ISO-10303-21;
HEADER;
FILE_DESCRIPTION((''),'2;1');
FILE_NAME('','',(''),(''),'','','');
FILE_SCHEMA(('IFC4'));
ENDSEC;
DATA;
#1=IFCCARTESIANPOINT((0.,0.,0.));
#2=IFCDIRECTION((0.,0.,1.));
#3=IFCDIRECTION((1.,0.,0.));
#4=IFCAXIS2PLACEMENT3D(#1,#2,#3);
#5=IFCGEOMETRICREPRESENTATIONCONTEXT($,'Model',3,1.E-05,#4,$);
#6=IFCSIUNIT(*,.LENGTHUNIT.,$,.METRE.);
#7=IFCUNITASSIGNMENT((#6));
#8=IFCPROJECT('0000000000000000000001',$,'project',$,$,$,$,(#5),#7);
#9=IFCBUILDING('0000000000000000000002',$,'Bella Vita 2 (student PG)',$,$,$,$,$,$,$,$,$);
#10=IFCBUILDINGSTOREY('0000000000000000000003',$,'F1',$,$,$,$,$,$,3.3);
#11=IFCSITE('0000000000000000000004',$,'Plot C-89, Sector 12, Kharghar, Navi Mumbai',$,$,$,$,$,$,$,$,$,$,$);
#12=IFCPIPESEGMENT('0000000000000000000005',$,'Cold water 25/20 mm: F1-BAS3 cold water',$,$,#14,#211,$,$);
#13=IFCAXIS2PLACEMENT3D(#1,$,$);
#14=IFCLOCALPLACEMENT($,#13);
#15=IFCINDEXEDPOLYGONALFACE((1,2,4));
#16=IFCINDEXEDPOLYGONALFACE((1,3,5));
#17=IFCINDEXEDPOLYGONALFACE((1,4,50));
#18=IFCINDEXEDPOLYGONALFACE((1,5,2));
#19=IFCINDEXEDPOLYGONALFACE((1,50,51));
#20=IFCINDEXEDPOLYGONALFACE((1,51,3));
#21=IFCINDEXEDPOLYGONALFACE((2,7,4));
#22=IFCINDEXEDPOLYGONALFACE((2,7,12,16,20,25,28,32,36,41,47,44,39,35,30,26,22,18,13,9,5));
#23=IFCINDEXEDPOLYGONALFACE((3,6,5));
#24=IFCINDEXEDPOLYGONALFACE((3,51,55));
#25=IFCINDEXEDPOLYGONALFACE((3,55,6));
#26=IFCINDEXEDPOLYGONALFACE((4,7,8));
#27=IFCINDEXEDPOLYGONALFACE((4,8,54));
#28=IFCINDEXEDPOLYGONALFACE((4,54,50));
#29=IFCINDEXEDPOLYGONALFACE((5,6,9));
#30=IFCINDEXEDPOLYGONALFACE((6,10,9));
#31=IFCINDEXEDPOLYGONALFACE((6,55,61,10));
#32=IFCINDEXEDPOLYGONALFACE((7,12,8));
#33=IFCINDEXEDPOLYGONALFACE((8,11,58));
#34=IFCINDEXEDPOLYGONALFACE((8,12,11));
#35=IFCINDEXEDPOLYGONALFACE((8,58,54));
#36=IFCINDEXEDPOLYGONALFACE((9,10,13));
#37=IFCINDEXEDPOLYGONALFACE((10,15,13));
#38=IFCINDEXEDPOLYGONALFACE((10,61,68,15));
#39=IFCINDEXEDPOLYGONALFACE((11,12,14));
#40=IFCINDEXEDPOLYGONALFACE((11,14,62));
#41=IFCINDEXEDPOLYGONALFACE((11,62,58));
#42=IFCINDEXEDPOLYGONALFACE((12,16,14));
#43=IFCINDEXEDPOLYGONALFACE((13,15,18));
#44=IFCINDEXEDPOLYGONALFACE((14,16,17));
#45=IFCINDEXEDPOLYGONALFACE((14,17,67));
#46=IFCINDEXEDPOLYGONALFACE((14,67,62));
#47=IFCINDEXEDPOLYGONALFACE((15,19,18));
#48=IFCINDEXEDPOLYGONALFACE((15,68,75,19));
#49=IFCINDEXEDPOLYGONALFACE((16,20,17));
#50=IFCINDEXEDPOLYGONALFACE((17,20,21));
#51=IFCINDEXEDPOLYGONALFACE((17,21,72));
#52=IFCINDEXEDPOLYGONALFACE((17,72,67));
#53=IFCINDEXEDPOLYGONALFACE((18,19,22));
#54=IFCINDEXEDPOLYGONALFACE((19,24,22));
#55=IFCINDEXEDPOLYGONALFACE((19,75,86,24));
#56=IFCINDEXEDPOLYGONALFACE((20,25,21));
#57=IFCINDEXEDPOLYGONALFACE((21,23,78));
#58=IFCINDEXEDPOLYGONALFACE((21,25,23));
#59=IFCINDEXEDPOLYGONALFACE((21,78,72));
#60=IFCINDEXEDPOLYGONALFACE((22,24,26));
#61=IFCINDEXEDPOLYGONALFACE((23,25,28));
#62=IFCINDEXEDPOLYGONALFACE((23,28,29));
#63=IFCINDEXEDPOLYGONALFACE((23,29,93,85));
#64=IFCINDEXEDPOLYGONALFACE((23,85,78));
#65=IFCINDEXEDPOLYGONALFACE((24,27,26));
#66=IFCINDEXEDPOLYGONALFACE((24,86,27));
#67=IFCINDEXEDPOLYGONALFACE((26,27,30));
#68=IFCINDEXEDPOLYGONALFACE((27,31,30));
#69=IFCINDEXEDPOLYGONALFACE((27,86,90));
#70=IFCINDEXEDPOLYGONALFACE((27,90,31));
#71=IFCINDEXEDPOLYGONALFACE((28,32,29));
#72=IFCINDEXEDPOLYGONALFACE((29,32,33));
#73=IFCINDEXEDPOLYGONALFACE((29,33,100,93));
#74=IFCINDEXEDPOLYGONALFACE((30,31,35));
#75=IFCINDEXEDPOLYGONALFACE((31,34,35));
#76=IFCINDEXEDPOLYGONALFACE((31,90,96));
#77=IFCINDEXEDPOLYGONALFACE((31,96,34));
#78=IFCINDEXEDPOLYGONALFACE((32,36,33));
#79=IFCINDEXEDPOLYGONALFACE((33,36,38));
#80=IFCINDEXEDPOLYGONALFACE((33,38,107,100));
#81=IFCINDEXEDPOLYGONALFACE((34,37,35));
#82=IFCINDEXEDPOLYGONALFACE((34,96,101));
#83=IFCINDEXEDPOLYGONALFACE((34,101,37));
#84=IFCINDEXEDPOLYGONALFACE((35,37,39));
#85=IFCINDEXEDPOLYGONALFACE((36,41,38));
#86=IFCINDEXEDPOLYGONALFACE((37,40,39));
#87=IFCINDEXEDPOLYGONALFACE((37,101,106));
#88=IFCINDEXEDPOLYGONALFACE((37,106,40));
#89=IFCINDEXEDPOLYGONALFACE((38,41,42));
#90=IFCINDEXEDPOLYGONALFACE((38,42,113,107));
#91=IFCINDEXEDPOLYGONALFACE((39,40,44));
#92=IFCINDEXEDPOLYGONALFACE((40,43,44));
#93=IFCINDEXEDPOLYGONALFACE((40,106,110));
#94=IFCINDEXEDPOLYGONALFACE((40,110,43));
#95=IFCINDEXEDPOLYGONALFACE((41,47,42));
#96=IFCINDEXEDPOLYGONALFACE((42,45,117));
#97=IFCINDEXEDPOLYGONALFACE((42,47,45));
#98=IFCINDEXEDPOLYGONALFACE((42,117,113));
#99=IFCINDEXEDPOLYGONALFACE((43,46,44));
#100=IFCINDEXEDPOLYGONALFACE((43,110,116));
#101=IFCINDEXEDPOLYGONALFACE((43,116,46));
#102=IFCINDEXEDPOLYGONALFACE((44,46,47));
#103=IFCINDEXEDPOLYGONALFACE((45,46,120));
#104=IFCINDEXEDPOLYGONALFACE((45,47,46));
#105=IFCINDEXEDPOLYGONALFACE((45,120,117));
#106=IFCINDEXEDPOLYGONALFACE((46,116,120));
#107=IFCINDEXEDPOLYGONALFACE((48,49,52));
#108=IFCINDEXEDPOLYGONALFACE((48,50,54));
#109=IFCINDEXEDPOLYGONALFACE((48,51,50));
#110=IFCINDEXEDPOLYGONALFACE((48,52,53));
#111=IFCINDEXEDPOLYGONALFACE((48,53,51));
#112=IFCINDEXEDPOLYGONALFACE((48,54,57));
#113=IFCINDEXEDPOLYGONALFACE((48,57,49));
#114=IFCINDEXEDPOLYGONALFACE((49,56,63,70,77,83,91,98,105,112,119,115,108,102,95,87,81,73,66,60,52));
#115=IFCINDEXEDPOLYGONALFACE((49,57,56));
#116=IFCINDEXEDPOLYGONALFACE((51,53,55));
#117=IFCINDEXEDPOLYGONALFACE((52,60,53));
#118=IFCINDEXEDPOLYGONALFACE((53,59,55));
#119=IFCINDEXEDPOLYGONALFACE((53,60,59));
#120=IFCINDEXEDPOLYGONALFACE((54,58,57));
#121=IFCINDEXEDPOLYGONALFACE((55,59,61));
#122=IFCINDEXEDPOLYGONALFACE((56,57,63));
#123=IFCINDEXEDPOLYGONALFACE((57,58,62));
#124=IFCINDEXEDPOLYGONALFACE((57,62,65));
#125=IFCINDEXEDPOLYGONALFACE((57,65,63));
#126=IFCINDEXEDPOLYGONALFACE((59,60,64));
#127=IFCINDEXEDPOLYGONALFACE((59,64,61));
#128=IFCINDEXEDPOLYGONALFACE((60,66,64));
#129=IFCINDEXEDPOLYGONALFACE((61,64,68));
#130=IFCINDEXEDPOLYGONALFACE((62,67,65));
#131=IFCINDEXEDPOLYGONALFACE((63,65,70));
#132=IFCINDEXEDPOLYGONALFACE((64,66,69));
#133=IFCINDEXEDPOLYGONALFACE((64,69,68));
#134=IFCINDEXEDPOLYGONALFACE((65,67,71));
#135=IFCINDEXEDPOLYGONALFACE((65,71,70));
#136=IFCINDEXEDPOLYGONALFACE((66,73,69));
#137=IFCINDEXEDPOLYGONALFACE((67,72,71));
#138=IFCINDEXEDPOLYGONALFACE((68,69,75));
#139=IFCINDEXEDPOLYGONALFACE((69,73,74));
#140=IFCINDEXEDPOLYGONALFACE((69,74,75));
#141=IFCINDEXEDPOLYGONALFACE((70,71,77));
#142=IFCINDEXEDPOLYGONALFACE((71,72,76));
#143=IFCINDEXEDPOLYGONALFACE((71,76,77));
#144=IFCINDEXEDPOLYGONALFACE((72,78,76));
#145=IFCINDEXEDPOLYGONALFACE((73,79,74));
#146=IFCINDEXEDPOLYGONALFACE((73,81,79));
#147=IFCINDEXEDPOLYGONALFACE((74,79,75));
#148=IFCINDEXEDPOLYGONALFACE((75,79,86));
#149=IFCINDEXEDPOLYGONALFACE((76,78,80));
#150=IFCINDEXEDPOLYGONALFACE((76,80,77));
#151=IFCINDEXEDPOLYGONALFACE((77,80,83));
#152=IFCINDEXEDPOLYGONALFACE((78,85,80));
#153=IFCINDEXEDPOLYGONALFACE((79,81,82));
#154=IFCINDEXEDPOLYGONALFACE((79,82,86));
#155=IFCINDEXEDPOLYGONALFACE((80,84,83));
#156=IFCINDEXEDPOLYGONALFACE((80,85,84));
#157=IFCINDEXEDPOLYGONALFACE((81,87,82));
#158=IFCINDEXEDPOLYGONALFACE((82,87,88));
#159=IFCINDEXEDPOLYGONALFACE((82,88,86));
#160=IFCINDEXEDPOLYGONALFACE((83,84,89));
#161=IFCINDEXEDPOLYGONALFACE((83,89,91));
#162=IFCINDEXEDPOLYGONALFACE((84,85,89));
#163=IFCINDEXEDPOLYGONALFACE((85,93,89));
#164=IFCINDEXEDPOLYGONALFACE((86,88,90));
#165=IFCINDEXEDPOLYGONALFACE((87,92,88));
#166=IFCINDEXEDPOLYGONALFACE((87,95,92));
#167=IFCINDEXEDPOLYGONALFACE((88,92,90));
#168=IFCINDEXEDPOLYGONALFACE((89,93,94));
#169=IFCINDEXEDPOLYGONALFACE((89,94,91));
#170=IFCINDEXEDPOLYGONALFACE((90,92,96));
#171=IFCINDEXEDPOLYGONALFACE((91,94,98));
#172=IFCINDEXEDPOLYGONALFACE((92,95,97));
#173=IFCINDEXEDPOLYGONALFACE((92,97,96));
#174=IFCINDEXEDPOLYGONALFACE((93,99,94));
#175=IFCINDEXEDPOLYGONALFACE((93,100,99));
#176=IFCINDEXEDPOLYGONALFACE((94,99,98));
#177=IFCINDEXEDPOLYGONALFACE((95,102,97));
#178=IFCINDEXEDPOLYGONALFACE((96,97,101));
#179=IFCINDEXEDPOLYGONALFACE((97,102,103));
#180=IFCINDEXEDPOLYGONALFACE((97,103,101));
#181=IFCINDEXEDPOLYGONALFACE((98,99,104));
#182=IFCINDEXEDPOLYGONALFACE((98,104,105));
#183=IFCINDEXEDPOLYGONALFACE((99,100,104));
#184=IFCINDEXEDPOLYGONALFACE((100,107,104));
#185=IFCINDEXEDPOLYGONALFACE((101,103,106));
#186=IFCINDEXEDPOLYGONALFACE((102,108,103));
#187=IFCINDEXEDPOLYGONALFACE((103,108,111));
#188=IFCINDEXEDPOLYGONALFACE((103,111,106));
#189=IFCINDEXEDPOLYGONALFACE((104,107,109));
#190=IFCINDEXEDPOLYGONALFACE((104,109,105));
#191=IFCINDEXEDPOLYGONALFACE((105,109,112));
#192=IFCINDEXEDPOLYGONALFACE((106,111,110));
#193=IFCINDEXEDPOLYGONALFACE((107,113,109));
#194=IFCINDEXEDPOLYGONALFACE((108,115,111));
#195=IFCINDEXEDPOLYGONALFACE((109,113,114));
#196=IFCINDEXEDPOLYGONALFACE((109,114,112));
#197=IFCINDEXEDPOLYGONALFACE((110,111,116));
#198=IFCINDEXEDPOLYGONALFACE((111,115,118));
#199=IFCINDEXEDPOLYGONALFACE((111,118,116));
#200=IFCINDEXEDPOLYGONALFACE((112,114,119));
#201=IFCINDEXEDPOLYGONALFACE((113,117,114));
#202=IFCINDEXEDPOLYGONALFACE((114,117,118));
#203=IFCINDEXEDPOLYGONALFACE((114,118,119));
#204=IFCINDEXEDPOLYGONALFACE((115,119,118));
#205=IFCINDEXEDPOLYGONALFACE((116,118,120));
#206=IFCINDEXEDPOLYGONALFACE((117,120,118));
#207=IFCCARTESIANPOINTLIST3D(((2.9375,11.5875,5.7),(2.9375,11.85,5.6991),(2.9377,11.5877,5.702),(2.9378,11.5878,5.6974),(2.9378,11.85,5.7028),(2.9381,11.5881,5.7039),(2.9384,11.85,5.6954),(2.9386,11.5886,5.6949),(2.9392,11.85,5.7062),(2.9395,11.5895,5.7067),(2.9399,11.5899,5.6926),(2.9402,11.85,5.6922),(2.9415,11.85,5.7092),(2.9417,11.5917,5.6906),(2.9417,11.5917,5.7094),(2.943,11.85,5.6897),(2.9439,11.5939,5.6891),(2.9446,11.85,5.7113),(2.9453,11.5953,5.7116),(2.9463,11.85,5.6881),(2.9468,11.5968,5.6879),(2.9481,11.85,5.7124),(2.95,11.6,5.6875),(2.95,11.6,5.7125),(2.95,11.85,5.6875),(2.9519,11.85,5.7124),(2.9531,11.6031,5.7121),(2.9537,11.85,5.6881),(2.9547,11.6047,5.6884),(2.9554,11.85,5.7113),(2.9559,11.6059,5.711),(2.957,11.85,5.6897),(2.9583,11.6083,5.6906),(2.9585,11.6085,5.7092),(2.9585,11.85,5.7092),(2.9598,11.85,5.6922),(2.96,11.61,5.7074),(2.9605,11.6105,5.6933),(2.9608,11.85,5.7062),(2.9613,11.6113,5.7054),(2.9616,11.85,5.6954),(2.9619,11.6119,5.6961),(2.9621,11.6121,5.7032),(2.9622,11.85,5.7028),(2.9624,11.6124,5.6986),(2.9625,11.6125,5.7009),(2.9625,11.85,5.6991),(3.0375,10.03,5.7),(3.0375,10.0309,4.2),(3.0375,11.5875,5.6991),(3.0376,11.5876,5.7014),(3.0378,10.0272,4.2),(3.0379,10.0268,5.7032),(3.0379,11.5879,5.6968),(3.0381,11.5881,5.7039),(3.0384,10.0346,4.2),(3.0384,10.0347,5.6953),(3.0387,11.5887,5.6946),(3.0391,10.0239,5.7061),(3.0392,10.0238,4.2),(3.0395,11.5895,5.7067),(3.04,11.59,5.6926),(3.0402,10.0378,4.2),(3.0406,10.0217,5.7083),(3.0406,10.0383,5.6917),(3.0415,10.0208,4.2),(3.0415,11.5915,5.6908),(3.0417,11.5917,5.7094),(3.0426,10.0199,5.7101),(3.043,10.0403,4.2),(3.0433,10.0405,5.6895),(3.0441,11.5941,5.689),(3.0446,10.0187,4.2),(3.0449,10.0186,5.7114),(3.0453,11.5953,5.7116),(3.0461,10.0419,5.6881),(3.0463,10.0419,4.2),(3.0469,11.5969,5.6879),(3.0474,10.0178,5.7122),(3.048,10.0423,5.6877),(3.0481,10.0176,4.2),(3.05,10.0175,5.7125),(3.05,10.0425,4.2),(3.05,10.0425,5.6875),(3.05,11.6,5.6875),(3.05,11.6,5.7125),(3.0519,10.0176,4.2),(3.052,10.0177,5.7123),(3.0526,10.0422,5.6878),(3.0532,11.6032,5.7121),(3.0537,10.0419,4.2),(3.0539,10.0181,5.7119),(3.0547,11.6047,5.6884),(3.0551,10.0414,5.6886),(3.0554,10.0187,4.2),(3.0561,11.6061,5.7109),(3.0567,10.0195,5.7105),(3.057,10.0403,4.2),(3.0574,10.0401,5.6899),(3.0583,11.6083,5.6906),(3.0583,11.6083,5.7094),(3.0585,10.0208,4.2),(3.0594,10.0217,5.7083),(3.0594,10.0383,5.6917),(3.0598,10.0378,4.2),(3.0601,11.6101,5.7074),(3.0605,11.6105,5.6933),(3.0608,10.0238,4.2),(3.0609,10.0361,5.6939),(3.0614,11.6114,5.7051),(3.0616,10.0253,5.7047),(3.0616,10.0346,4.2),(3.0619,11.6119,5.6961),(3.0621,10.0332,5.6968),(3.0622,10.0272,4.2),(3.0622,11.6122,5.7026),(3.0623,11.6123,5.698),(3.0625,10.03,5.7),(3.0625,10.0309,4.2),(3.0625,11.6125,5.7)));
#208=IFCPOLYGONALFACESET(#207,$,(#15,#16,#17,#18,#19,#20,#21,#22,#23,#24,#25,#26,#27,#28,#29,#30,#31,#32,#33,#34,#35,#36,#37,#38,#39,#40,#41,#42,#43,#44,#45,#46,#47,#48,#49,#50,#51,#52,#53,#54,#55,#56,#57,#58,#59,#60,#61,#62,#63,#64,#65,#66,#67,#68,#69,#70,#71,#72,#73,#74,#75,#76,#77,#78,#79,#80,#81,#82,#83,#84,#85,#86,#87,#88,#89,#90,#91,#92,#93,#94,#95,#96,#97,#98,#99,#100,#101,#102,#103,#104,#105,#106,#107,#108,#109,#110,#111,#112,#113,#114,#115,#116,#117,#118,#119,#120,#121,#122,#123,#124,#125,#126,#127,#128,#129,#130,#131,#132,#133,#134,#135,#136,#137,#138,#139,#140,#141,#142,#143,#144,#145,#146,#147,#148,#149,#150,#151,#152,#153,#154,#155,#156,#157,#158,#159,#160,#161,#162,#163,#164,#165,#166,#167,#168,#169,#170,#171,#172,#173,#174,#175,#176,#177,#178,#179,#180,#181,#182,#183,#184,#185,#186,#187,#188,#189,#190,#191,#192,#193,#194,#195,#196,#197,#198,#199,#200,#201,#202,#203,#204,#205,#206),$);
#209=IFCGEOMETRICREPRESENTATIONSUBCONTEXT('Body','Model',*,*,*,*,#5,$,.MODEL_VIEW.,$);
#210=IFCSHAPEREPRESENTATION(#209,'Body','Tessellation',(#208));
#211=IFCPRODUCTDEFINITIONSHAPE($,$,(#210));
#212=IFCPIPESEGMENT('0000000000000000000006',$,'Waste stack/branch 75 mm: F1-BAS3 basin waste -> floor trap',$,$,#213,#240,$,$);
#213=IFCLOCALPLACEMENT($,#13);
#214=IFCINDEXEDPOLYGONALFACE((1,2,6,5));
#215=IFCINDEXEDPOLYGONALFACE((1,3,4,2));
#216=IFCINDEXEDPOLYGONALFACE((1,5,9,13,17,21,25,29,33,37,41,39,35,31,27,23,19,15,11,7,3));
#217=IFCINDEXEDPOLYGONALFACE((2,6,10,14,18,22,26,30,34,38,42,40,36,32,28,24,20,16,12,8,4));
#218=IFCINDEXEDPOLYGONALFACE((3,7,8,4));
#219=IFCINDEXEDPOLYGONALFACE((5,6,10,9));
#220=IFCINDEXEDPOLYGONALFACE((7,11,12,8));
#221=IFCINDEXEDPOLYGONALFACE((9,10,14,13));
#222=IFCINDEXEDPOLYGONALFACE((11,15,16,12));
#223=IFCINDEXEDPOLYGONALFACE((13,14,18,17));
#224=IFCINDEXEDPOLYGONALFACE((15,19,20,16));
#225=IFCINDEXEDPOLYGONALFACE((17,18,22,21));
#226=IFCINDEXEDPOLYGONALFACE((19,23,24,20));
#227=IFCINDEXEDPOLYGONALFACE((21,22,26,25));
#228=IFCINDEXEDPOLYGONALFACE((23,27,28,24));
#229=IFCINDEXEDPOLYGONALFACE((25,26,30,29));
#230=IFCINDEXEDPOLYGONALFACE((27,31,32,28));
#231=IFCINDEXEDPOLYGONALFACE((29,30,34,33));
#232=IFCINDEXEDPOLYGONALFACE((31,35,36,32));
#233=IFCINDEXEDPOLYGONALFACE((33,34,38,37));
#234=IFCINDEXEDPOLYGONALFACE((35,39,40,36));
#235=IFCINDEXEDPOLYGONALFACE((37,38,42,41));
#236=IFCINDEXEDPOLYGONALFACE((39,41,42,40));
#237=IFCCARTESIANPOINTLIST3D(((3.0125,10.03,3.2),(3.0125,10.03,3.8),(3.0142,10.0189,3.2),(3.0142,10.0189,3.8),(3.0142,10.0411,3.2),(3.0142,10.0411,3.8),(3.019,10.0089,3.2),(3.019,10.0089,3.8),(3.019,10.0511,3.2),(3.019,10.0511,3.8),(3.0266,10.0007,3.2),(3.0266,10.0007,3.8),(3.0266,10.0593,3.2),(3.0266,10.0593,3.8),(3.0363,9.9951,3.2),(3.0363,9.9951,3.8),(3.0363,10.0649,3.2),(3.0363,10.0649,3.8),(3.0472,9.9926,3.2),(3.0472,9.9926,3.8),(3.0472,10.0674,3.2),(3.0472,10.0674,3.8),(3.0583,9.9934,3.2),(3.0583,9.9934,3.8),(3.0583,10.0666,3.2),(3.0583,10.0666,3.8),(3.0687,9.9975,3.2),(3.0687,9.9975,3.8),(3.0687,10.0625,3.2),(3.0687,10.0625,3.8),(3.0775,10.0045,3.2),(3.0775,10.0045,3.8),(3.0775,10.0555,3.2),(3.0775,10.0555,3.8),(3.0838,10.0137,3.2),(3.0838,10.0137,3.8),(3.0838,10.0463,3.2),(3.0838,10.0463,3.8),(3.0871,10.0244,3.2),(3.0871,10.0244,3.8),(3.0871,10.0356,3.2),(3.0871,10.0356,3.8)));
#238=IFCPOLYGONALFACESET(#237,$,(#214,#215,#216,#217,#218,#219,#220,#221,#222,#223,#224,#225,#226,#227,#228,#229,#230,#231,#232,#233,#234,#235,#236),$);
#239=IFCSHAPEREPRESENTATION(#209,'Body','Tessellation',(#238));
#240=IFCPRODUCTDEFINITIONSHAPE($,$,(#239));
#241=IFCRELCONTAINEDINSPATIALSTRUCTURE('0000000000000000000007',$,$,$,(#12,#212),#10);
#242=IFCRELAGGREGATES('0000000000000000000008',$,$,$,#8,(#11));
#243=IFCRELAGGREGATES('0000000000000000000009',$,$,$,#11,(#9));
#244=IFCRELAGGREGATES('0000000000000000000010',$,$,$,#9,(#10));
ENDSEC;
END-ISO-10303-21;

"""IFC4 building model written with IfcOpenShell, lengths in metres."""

from ifc_helpers import new_model, entity, si_unit, origin, origin_with_axes, place, context, subcontext, project, spatial, element, save


model = new_model("IFC4")

# Units and contexts
model_context = context("Model", 3, precision=1e-05, world=origin_with_axes())
body_context = subcontext(model_context, "Body", "Model", "MODEL_VIEW")
ifc_project = project(units=[si_unit("LENGTHUNIT", "METRE")], contexts=[model_context])

# Site, building, storey
site = spatial("IfcSite", under=ifc_project, Name="Plot C-89, Sector 12, Kharghar, Navi Mumbai")
building = spatial("IfcBuilding", under=site, Name="Bella Vita 2 (student PG)")
storey = spatial("IfcBuildingStorey", under=building, Name="F1", Elevation=3.3)

# Pipe segments
pipe_segment_1_placement = place(None, origin())
element("IfcPipeSegment", 1, at=pipe_segment_1_placement, inside=storey, Name="Cold water 25/20 mm: F1-BAS3 cold water", context=body_context, shape_type="AdvancedSweptSolid", body=[
    entity("IfcSweptDiskSolid", entity("IfcPolyline", [entity("IfcCartesianPoint", [2.95, 11.85, 5.7]), entity("IfcCartesianPoint", [2.95, 11.6, 5.7]), entity("IfcCartesianPoint", [3.05, 11.6, 5.7]), entity("IfcCartesianPoint", [3.05, 10.03, 5.7]), entity("IfcCartesianPoint", [3.05, 10.03, 4.2])]), 0.0125),
])
pipe_segment_2_placement = place(None, origin())
element("IfcPipeSegment", 2, at=pipe_segment_2_placement, inside=storey, Name="Waste stack/branch 75 mm: F1-BAS3 basin waste -> floor trap", context=body_context, shape_type="AdvancedSweptSolid", body=[
    entity("IfcSweptDiskSolid", entity("IfcPolyline", [entity("IfcCartesianPoint", [3.05, 10.03, 3.8]), entity("IfcCartesianPoint", [3.05, 10.03, 3.2])]), 0.0375),
])

save(model, "model.ifc")
